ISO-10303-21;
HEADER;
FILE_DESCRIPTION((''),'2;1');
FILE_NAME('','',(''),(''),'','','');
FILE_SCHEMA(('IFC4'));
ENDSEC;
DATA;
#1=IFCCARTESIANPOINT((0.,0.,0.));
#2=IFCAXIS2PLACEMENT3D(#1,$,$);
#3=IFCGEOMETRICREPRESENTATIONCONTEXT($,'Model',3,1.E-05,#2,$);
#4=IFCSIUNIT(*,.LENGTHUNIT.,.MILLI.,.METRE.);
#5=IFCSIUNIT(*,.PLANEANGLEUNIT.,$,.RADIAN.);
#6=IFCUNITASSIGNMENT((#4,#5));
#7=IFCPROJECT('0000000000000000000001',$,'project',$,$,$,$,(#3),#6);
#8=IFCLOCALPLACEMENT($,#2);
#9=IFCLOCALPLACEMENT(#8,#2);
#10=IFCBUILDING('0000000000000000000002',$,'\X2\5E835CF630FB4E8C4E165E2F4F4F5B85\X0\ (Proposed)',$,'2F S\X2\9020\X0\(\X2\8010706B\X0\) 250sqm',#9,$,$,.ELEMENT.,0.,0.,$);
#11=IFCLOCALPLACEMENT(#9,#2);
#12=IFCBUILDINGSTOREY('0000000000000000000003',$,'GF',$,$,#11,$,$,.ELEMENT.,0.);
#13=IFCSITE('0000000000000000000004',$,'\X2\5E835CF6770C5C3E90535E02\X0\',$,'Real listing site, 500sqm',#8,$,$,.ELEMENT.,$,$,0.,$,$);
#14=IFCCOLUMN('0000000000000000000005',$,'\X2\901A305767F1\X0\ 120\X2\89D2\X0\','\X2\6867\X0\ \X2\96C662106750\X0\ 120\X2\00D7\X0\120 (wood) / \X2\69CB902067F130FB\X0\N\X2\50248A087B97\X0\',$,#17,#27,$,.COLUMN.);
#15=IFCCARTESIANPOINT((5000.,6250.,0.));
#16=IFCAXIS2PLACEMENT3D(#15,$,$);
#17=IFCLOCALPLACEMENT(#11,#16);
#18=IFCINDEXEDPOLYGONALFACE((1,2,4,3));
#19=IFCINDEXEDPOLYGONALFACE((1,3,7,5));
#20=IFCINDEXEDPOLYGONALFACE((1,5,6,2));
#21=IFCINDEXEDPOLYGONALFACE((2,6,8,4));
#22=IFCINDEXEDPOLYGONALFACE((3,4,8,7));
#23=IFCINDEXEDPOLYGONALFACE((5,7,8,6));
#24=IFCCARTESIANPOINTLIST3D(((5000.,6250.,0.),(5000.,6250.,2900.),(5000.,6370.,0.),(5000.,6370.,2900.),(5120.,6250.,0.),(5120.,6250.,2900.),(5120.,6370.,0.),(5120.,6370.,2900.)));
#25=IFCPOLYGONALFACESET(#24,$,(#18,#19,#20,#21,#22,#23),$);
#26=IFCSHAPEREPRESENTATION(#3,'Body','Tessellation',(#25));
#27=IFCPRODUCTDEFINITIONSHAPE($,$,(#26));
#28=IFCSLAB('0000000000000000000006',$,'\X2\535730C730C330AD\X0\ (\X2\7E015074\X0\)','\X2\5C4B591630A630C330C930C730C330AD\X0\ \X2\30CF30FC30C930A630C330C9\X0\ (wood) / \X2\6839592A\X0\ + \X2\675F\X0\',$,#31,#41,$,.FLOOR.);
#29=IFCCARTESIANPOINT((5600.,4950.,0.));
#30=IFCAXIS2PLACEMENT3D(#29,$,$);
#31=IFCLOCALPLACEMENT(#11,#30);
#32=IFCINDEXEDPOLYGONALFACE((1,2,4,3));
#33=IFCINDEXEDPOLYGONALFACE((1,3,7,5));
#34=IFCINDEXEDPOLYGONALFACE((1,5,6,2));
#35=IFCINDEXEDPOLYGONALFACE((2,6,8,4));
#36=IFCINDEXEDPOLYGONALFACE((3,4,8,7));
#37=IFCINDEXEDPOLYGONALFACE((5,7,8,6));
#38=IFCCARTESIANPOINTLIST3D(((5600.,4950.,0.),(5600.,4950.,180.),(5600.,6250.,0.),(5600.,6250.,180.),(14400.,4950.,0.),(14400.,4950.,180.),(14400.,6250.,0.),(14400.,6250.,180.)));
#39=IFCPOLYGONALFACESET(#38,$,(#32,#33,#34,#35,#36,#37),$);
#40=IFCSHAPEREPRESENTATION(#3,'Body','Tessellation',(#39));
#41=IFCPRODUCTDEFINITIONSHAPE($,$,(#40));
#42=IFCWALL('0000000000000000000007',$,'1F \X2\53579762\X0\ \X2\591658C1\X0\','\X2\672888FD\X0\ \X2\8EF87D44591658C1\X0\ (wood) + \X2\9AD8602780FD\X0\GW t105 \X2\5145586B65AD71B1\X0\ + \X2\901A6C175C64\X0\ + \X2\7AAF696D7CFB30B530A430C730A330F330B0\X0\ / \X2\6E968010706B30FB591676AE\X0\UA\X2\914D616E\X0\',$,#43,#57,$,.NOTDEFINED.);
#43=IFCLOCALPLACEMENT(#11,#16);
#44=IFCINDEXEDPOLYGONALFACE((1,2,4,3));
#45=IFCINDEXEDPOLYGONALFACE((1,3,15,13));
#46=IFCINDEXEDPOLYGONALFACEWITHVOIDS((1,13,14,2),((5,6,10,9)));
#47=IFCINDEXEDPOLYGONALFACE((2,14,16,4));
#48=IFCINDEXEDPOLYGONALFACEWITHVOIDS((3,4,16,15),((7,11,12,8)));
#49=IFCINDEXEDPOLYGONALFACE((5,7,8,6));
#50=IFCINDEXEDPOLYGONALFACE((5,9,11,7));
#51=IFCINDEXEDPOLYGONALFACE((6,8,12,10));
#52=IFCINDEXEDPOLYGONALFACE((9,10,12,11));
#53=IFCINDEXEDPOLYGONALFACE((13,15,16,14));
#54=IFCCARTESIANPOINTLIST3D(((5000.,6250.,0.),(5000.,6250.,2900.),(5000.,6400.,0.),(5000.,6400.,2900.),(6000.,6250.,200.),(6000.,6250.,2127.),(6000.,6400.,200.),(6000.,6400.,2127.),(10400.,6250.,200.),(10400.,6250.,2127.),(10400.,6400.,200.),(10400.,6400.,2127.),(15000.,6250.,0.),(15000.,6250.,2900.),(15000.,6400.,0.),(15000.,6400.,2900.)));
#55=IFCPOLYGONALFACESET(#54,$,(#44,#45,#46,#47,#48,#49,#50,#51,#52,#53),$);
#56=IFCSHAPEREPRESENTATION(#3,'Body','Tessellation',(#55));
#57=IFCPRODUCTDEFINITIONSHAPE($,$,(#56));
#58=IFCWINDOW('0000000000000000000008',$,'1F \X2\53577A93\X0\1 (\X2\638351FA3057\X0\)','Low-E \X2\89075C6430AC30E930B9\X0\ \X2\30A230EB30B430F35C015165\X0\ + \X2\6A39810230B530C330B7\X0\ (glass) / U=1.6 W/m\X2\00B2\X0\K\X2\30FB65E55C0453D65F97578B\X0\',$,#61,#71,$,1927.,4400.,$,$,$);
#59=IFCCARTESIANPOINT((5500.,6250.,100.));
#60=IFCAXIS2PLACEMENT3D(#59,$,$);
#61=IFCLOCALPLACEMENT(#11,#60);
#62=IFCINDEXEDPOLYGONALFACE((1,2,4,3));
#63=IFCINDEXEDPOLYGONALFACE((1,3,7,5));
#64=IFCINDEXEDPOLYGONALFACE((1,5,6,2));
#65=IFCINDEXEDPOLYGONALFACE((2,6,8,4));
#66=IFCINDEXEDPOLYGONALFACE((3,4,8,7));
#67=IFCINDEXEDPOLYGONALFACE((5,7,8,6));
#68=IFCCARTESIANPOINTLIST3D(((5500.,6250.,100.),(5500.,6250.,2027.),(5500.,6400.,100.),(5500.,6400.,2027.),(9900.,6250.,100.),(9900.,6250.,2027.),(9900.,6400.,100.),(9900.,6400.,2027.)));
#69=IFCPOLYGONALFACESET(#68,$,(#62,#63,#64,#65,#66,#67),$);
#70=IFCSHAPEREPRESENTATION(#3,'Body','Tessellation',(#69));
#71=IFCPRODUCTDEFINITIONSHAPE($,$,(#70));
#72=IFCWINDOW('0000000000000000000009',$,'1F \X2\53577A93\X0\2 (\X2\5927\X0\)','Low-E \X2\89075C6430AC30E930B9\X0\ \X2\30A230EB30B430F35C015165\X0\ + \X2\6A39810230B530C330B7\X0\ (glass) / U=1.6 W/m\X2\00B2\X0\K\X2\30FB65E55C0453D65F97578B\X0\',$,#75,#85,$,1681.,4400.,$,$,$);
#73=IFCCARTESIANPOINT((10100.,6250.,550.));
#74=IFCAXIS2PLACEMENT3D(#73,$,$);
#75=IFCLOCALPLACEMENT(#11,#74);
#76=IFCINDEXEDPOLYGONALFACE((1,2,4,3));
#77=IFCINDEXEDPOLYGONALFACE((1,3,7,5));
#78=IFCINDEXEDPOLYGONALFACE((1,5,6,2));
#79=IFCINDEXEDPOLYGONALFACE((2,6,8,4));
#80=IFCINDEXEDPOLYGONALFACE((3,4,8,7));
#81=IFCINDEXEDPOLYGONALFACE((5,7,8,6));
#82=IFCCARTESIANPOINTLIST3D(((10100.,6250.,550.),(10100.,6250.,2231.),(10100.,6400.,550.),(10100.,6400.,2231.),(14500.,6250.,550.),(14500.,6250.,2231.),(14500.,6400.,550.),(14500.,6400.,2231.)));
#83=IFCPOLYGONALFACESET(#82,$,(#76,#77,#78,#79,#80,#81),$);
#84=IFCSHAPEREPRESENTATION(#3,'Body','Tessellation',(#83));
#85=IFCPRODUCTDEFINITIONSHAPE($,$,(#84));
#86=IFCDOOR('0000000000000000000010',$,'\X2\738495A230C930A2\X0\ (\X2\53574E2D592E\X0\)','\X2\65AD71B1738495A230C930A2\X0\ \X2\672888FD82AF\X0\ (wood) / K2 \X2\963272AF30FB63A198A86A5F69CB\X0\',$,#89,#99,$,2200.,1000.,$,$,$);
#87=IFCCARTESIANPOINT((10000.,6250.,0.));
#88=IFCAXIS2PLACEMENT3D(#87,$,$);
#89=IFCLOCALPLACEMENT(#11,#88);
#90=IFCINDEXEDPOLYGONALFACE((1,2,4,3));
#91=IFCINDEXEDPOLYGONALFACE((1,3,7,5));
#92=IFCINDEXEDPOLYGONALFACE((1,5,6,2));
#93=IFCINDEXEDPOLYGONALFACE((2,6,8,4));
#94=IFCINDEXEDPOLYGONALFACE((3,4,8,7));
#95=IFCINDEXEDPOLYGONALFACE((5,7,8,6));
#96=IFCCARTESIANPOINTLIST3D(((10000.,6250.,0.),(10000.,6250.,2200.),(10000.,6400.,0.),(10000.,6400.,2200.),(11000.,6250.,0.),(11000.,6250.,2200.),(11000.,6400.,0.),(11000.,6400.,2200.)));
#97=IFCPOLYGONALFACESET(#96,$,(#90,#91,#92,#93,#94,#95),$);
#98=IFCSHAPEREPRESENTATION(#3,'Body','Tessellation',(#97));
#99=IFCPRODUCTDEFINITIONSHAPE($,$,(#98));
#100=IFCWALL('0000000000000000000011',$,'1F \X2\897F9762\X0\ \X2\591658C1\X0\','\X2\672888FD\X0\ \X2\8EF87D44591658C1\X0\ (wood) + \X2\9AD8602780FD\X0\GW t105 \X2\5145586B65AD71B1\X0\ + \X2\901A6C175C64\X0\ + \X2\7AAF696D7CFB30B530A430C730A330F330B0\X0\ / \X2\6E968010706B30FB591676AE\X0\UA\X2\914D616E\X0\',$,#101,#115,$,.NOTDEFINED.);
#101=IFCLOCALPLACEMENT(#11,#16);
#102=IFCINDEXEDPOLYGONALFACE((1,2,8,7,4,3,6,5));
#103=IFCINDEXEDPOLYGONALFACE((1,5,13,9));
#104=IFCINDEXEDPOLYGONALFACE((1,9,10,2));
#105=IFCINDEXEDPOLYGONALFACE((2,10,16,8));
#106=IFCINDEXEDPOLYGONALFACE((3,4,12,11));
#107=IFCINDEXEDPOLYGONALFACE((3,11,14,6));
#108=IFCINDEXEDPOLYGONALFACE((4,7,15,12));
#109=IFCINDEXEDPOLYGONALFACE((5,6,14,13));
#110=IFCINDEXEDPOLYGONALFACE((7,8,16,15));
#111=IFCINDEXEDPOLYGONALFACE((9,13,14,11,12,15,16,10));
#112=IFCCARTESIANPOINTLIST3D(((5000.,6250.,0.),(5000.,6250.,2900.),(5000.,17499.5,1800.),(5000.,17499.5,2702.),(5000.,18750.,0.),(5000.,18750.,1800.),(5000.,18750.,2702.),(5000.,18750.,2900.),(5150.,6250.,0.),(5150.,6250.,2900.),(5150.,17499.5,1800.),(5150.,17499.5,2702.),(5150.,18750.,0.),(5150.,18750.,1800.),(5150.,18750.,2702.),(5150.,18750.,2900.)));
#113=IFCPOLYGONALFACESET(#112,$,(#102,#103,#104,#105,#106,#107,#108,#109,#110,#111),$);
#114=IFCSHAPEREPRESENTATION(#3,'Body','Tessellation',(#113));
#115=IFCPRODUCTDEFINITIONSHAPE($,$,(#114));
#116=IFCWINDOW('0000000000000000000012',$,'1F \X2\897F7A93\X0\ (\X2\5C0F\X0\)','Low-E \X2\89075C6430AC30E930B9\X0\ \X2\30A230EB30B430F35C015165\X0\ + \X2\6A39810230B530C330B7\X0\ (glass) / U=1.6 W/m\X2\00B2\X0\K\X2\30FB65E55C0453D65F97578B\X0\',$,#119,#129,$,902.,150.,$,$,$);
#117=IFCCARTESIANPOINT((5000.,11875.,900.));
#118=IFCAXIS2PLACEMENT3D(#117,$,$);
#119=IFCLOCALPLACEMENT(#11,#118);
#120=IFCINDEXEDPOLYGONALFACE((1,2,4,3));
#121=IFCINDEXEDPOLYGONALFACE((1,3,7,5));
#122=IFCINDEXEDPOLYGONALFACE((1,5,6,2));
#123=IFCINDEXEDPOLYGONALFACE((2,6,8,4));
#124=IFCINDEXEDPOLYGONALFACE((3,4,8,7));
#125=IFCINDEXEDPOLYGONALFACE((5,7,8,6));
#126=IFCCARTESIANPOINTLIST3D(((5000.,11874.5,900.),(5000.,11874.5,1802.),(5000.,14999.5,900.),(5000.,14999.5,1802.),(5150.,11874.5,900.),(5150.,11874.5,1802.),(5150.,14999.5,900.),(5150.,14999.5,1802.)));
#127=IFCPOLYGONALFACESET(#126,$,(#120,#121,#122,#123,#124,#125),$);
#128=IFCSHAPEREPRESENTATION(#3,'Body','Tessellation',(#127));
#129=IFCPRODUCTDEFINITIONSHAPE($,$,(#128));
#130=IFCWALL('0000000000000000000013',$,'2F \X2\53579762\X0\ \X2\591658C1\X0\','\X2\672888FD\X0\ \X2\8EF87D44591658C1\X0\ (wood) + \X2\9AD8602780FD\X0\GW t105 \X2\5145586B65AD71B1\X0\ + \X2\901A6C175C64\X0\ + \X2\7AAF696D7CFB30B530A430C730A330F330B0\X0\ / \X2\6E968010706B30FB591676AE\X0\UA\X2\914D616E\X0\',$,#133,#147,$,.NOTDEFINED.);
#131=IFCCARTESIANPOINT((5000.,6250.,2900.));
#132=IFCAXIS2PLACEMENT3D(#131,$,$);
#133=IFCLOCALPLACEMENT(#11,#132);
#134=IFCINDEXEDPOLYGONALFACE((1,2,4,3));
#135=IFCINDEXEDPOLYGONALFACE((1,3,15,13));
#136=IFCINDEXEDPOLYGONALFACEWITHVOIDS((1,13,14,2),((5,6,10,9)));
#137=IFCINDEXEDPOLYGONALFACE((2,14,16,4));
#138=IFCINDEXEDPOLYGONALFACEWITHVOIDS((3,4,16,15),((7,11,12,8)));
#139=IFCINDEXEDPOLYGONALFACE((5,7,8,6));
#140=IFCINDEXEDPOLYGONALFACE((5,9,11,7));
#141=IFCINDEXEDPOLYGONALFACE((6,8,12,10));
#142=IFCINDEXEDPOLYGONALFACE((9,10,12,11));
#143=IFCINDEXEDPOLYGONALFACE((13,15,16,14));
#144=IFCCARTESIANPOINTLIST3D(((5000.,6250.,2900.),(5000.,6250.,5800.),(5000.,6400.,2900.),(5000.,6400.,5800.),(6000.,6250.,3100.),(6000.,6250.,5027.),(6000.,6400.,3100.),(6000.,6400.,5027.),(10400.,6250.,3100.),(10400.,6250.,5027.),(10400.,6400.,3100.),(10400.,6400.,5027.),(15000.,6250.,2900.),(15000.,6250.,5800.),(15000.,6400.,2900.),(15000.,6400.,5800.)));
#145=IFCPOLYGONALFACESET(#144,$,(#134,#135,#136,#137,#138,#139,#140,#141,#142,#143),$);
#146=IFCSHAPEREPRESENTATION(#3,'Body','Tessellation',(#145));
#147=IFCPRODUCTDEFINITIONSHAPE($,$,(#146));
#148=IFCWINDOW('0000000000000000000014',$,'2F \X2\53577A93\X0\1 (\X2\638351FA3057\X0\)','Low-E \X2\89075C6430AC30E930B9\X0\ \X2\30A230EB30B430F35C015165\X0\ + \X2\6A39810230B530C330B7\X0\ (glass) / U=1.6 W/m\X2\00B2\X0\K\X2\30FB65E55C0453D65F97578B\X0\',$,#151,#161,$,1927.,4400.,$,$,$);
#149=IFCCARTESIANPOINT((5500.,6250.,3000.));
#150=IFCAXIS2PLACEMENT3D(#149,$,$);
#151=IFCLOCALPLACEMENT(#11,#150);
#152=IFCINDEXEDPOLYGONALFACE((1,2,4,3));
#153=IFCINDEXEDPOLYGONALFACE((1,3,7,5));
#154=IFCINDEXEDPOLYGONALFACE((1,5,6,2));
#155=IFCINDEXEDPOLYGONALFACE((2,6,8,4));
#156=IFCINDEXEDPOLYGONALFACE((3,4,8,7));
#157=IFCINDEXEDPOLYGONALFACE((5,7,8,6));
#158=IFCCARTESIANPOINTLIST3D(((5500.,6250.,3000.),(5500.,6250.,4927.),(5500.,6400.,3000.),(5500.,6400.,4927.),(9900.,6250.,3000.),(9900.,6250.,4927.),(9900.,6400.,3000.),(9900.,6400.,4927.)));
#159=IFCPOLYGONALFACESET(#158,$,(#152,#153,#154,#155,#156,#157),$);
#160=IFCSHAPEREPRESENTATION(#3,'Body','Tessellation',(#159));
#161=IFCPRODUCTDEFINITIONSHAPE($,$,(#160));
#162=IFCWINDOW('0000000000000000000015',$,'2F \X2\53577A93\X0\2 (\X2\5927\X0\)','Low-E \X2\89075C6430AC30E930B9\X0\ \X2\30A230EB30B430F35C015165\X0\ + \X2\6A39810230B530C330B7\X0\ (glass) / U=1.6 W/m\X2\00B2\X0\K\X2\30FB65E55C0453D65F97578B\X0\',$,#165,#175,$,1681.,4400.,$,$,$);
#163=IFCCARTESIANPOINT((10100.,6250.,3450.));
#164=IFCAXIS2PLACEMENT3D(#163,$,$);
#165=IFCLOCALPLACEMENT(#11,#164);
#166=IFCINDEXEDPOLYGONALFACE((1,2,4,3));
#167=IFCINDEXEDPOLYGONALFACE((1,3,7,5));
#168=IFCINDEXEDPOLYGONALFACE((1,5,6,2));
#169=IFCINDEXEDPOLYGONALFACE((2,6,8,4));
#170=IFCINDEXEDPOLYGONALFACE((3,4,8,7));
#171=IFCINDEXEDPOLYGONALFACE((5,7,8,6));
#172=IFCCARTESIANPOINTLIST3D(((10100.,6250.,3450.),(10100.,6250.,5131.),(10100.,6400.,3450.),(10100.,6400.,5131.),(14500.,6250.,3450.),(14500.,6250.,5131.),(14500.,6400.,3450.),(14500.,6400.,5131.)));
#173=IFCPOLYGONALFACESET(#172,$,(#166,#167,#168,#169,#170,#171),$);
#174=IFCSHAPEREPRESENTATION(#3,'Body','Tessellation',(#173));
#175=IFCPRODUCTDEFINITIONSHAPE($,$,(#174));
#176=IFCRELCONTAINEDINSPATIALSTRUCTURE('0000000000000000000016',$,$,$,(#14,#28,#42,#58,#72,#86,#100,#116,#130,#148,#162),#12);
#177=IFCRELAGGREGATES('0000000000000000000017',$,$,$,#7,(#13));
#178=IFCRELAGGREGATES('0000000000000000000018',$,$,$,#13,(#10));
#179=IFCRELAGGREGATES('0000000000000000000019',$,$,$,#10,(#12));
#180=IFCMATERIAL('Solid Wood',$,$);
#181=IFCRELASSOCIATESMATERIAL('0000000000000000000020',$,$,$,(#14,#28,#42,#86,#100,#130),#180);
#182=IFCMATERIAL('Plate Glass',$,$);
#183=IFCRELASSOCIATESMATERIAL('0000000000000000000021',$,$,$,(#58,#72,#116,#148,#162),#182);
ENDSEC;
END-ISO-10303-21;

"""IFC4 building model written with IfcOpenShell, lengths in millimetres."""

from ifc_helpers import new_model, si_unit, frame, frame_2d, origin, place, context, project, spatial, rectangle, extrude, material, element, fill, save


model = new_model("IFC4")

# Units and contexts
model_context = context("Model", 3, precision=1e-05, world=origin())
ifc_project = project(units=[si_unit("LENGTHUNIT", "METRE", prefix="MILLI"), si_unit("PLANEANGLEUNIT", "RADIAN")], contexts=[model_context])

# Site, building, storey
site_placement = place(None, origin())
site = spatial("IfcSite", under=ifc_project, at=site_placement, Name="広島県尾道市", ObjectType="Real listing site, 500sqm", CompositionType="ELEMENT", RefElevation=0.0)
building_placement = place(site_placement, origin())
building = spatial("IfcBuilding", under=site, at=building_placement, Name="広島・二世帯住宅 (Proposed)", ObjectType="2F S造(耐火) 250sqm", CompositionType="ELEMENT", ElevationOfRefHeight=0.0, ElevationOfTerrain=0.0)
storey_placement = place(building_placement, origin())
storey = spatial("IfcBuildingStorey", under=building, at=storey_placement, Name="GF", CompositionType="ELEMENT", Elevation=0.0)

# Column
ifc_material_1 = material(Name="Solid Wood")
column_placement = place(storey_placement, frame((5000.0, 6250.0, 0.0)))
element("IfcColumn", 1, at=column_placement, inside=storey, material=ifc_material_1, Name="通し柱 120角", Description="桧 集成材 120×120 (wood) / 構造柱・N値計算", PredefinedType="COLUMN", context=model_context, shape_type="SweptSolid", body=[
    extrude(rectangle(XDim=120.0, YDim=120.0, at=frame_2d((60.0, 60.0))), frame((5000.0, 6250.0, 0.0)), (0.0, 0.0, 1.0), 2900.0),
])

# Slab
slab_1_placement = place(storey_placement, frame((5600.0, 4950.0, 0.0)))
element("IfcSlab", 2, at=slab_1_placement, inside=storey, material=ifc_material_1, Name="南デッキ (縁側)", Description="屋外ウッドデッキ ハードウッド (wood) / 根太 + 束", PredefinedType="FLOOR", context=model_context, shape_type="SweptSolid", body=[
    extrude(rectangle(XDim=8800.0, YDim=1300.0, at=frame_2d((4400.0, 650.0))), frame((5600.0, 4950.0, 0.0)), (0.0, 0.0, 1.0), 180.0),
])

# Wall, openings, windows, door
wall_1_placement = place(storey_placement, frame((5000.0, 6250.0, 0.0)))
wall_1 = element("IfcWall", 3, at=wall_1_placement, inside=storey, material=ifc_material_1, Name="1F 南面 外壁", Description="木製 軸組外壁 (wood) + 高性能GW t105 充填断熱 + 通気層 + 窯業系サイディング / 準耐火・外皮UA配慮", PredefinedType="NOTDEFINED", context=model_context, shape_type="SweptSolid", body=[
    extrude(rectangle(XDim=10000.0, YDim=150.0, at=frame_2d((5000.0, 75.0))), frame((5000.0, 6250.0, 0.0)), (0.0, 0.0, 1.0), 2900.0),
])
opening_1_placement = place(storey_placement, frame((5500.0, 6250.0, 100.0)))
opening_1 = element("IfcOpeningElement", 4, at=opening_1_placement, cuts=wall_1, PredefinedType="NOTDEFINED", context=model_context, shape_type="SweptSolid", body=[
    extrude(rectangle(XDim=4400.0, YDim=150.0, at=frame_2d((2200.0, 75.0))), frame((5500.0, 6250.0, 100.0)), (0.0, 0.0, 1.0), 1927.0),
])
opening_2_placement = place(storey_placement, frame((10100.0, 6250.0, 550.0)))
opening_2 = element("IfcOpeningElement", 5, at=opening_2_placement, cuts=wall_1, PredefinedType="NOTDEFINED", context=model_context, shape_type="SweptSolid", body=[
    extrude(rectangle(XDim=4400.0, YDim=150.0, at=frame_2d((2200.0, 75.0))), frame((10100.0, 6250.0, 550.0)), (0.0, 0.0, 1.0), 1681.0),
])
opening_3_placement = place(storey_placement, frame((10000.0, 6250.0, 0.0)))
opening_3 = element("IfcOpeningElement", 6, at=opening_3_placement, cuts=wall_1, PredefinedType="NOTDEFINED", context=model_context, shape_type="SweptSolid", body=[
    extrude(rectangle(XDim=1000.0, YDim=150.0, at=frame_2d((500.0, 75.0))), frame((10000.0, 6250.0, 0.0)), (0.0, 0.0, 1.0), 2200.0),
])
ifc_material_2 = material(Name="Plate Glass")
window_1_placement = place(storey_placement, frame((5500.0, 6250.0, 100.0)))
window_1 = element("IfcWindow", 7, at=window_1_placement, inside=storey, material=ifc_material_2, Name="1F 南窓1 (掃出し)", Description="Low-E 複層ガラス アルゴン封入 + 樹脂サッシ (glass) / U=1.6 W/m²K・日射取得型", OverallHeight=1927.0, OverallWidth=4400.0, context=model_context, shape_type="SweptSolid", body=[
    extrude(rectangle(XDim=4400.0, YDim=150.0, at=frame_2d((2200.0, 75.0))), frame((5500.0, 6250.0, 100.0)), (0.0, 0.0, 1.0), 1927.0),
])
fill(opening_1, window_1)
window_2_placement = place(storey_placement, frame((10100.0, 6250.0, 550.0)))
window_2 = element("IfcWindow", 8, at=window_2_placement, inside=storey, material=ifc_material_2, Name="1F 南窓2 (大)", Description="Low-E 複層ガラス アルゴン封入 + 樹脂サッシ (glass) / U=1.6 W/m²K・日射取得型", OverallHeight=1681.0, OverallWidth=4400.0, context=model_context, shape_type="SweptSolid", body=[
    extrude(rectangle(XDim=4400.0, YDim=150.0, at=frame_2d((2200.0, 75.0))), frame((10100.0, 6250.0, 550.0)), (0.0, 0.0, 1.0), 1681.0),
])
fill(opening_2, window_2)
door_placement = place(storey_placement, frame((10000.0, 6250.0, 0.0)))
door = element("IfcDoor", 9, at=door_placement, inside=storey, material=ifc_material_1, Name="玄関ドア (南中央)", Description="断熱玄関ドア 木製芯 (wood) / K2 防犯・採風機構", OverallHeight=2200.0, OverallWidth=1000.0, context=model_context, shape_type="SweptSolid", body=[
    extrude(rectangle(XDim=1000.0, YDim=150.0, at=frame_2d((500.0, 75.0))), frame((10000.0, 6250.0, 0.0)), (0.0, 0.0, 1.0), 2200.0),
])
fill(opening_3, door)

# Wall, opening, window
wall_2_placement = place(storey_placement, frame((5000.0, 6250.0, 0.0)))
wall_2 = element("IfcWall", 10, at=wall_2_placement, inside=storey, material=ifc_material_1, Name="1F 西面 外壁", Description="木製 軸組外壁 (wood) + 高性能GW t105 充填断熱 + 通気層 + 窯業系サイディング / 準耐火・外皮UA配慮", PredefinedType="NOTDEFINED", context=model_context, shape_type="SweptSolid", body=[
    extrude(rectangle(XDim=150.0, YDim=12500.0, at=frame_2d((75.0, 6250.0))), frame((5000.0, 6250.0, 0.0)), (0.0, 0.0, 1.0), 2900.0),
])
opening_4_placement = place(storey_placement, frame((5000.0, 11875.0, 900.0)))
opening_4 = element("IfcOpeningElement", 11, at=opening_4_placement, cuts=wall_2, PredefinedType="NOTDEFINED", context=model_context, shape_type="SweptSolid", body=[
    extrude(rectangle(XDim=150.0, YDim=3125.0, at=frame_2d((75.0, 1562.0))), frame((5000.0, 11875.0, 900.0)), (0.0, 0.0, 1.0), 902.0),
])
window_3_placement = place(storey_placement, frame((5000.0, 11875.0, 900.0)))
window_3 = element("IfcWindow", 12, at=window_3_placement, inside=storey, material=ifc_material_2, Name="1F 西窓 (小)", Description="Low-E 複層ガラス アルゴン封入 + 樹脂サッシ (glass) / U=1.6 W/m²K・日射取得型", OverallHeight=902.0, OverallWidth=150.0, context=model_context, shape_type="SweptSolid", body=[
    extrude(rectangle(XDim=150.0, YDim=3125.0, at=frame_2d((75.0, 1562.0))), frame((5000.0, 11875.0, 900.0)), (0.0, 0.0, 1.0), 902.0),
])
fill(opening_4, window_3)

# Wall, openings, windows
wall_3_placement = place(storey_placement, frame((5000.0, 6250.0, 2900.0)))
wall_3 = element("IfcWall", 13, at=wall_3_placement, inside=storey, material=ifc_material_1, Name="2F 南面 外壁", Description="木製 軸組外壁 (wood) + 高性能GW t105 充填断熱 + 通気層 + 窯業系サイディング / 準耐火・外皮UA配慮", PredefinedType="NOTDEFINED", context=model_context, shape_type="SweptSolid", body=[
    extrude(rectangle(XDim=10000.0, YDim=150.0, at=frame_2d((5000.0, 75.0))), frame((5000.0, 6250.0, 2900.0)), (0.0, 0.0, 1.0), 2900.0),
])
opening_5_placement = place(storey_placement, frame((5500.0, 6250.0, 3000.0)))
opening_5 = element("IfcOpeningElement", 14, at=opening_5_placement, cuts=wall_3, PredefinedType="NOTDEFINED", context=model_context, shape_type="SweptSolid", body=[
    extrude(rectangle(XDim=4400.0, YDim=150.0, at=frame_2d((2200.0, 75.0))), frame((5500.0, 6250.0, 3000.0)), (0.0, 0.0, 1.0), 1927.0),
])
opening_6_placement = place(storey_placement, frame((10100.0, 6250.0, 3450.0)))
opening_6 = element("IfcOpeningElement", 15, at=opening_6_placement, cuts=wall_3, PredefinedType="NOTDEFINED", context=model_context, shape_type="SweptSolid", body=[
    extrude(rectangle(XDim=4400.0, YDim=150.0, at=frame_2d((2200.0, 75.0))), frame((10100.0, 6250.0, 3450.0)), (0.0, 0.0, 1.0), 1681.0),
])
window_4_placement = place(storey_placement, frame((5500.0, 6250.0, 3000.0)))
window_4 = element("IfcWindow", 16, at=window_4_placement, inside=storey, material=ifc_material_2, Name="2F 南窓1 (掃出し)", Description="Low-E 複層ガラス アルゴン封入 + 樹脂サッシ (glass) / U=1.6 W/m²K・日射取得型", OverallHeight=1927.0, OverallWidth=4400.0, context=model_context, shape_type="SweptSolid", body=[
    extrude(rectangle(XDim=4400.0, YDim=150.0, at=frame_2d((2200.0, 75.0))), frame((5500.0, 6250.0, 3000.0)), (0.0, 0.0, 1.0), 1927.0),
])
fill(opening_5, window_4)
window_5_placement = place(storey_placement, frame((10100.0, 6250.0, 3450.0)))
window_5 = element("IfcWindow", 17, at=window_5_placement, inside=storey, material=ifc_material_2, Name="2F 南窓2 (大)", Description="Low-E 複層ガラス アルゴン封入 + 樹脂サッシ (glass) / U=1.6 W/m²K・日射取得型", OverallHeight=1681.0, OverallWidth=4400.0, context=model_context, shape_type="SweptSolid", body=[
    extrude(rectangle(XDim=4400.0, YDim=150.0, at=frame_2d((2200.0, 75.0))), frame((10100.0, 6250.0, 3450.0)), (0.0, 0.0, 1.0), 1681.0),
])
fill(opening_6, window_5)

save(model, "model.ifc")
